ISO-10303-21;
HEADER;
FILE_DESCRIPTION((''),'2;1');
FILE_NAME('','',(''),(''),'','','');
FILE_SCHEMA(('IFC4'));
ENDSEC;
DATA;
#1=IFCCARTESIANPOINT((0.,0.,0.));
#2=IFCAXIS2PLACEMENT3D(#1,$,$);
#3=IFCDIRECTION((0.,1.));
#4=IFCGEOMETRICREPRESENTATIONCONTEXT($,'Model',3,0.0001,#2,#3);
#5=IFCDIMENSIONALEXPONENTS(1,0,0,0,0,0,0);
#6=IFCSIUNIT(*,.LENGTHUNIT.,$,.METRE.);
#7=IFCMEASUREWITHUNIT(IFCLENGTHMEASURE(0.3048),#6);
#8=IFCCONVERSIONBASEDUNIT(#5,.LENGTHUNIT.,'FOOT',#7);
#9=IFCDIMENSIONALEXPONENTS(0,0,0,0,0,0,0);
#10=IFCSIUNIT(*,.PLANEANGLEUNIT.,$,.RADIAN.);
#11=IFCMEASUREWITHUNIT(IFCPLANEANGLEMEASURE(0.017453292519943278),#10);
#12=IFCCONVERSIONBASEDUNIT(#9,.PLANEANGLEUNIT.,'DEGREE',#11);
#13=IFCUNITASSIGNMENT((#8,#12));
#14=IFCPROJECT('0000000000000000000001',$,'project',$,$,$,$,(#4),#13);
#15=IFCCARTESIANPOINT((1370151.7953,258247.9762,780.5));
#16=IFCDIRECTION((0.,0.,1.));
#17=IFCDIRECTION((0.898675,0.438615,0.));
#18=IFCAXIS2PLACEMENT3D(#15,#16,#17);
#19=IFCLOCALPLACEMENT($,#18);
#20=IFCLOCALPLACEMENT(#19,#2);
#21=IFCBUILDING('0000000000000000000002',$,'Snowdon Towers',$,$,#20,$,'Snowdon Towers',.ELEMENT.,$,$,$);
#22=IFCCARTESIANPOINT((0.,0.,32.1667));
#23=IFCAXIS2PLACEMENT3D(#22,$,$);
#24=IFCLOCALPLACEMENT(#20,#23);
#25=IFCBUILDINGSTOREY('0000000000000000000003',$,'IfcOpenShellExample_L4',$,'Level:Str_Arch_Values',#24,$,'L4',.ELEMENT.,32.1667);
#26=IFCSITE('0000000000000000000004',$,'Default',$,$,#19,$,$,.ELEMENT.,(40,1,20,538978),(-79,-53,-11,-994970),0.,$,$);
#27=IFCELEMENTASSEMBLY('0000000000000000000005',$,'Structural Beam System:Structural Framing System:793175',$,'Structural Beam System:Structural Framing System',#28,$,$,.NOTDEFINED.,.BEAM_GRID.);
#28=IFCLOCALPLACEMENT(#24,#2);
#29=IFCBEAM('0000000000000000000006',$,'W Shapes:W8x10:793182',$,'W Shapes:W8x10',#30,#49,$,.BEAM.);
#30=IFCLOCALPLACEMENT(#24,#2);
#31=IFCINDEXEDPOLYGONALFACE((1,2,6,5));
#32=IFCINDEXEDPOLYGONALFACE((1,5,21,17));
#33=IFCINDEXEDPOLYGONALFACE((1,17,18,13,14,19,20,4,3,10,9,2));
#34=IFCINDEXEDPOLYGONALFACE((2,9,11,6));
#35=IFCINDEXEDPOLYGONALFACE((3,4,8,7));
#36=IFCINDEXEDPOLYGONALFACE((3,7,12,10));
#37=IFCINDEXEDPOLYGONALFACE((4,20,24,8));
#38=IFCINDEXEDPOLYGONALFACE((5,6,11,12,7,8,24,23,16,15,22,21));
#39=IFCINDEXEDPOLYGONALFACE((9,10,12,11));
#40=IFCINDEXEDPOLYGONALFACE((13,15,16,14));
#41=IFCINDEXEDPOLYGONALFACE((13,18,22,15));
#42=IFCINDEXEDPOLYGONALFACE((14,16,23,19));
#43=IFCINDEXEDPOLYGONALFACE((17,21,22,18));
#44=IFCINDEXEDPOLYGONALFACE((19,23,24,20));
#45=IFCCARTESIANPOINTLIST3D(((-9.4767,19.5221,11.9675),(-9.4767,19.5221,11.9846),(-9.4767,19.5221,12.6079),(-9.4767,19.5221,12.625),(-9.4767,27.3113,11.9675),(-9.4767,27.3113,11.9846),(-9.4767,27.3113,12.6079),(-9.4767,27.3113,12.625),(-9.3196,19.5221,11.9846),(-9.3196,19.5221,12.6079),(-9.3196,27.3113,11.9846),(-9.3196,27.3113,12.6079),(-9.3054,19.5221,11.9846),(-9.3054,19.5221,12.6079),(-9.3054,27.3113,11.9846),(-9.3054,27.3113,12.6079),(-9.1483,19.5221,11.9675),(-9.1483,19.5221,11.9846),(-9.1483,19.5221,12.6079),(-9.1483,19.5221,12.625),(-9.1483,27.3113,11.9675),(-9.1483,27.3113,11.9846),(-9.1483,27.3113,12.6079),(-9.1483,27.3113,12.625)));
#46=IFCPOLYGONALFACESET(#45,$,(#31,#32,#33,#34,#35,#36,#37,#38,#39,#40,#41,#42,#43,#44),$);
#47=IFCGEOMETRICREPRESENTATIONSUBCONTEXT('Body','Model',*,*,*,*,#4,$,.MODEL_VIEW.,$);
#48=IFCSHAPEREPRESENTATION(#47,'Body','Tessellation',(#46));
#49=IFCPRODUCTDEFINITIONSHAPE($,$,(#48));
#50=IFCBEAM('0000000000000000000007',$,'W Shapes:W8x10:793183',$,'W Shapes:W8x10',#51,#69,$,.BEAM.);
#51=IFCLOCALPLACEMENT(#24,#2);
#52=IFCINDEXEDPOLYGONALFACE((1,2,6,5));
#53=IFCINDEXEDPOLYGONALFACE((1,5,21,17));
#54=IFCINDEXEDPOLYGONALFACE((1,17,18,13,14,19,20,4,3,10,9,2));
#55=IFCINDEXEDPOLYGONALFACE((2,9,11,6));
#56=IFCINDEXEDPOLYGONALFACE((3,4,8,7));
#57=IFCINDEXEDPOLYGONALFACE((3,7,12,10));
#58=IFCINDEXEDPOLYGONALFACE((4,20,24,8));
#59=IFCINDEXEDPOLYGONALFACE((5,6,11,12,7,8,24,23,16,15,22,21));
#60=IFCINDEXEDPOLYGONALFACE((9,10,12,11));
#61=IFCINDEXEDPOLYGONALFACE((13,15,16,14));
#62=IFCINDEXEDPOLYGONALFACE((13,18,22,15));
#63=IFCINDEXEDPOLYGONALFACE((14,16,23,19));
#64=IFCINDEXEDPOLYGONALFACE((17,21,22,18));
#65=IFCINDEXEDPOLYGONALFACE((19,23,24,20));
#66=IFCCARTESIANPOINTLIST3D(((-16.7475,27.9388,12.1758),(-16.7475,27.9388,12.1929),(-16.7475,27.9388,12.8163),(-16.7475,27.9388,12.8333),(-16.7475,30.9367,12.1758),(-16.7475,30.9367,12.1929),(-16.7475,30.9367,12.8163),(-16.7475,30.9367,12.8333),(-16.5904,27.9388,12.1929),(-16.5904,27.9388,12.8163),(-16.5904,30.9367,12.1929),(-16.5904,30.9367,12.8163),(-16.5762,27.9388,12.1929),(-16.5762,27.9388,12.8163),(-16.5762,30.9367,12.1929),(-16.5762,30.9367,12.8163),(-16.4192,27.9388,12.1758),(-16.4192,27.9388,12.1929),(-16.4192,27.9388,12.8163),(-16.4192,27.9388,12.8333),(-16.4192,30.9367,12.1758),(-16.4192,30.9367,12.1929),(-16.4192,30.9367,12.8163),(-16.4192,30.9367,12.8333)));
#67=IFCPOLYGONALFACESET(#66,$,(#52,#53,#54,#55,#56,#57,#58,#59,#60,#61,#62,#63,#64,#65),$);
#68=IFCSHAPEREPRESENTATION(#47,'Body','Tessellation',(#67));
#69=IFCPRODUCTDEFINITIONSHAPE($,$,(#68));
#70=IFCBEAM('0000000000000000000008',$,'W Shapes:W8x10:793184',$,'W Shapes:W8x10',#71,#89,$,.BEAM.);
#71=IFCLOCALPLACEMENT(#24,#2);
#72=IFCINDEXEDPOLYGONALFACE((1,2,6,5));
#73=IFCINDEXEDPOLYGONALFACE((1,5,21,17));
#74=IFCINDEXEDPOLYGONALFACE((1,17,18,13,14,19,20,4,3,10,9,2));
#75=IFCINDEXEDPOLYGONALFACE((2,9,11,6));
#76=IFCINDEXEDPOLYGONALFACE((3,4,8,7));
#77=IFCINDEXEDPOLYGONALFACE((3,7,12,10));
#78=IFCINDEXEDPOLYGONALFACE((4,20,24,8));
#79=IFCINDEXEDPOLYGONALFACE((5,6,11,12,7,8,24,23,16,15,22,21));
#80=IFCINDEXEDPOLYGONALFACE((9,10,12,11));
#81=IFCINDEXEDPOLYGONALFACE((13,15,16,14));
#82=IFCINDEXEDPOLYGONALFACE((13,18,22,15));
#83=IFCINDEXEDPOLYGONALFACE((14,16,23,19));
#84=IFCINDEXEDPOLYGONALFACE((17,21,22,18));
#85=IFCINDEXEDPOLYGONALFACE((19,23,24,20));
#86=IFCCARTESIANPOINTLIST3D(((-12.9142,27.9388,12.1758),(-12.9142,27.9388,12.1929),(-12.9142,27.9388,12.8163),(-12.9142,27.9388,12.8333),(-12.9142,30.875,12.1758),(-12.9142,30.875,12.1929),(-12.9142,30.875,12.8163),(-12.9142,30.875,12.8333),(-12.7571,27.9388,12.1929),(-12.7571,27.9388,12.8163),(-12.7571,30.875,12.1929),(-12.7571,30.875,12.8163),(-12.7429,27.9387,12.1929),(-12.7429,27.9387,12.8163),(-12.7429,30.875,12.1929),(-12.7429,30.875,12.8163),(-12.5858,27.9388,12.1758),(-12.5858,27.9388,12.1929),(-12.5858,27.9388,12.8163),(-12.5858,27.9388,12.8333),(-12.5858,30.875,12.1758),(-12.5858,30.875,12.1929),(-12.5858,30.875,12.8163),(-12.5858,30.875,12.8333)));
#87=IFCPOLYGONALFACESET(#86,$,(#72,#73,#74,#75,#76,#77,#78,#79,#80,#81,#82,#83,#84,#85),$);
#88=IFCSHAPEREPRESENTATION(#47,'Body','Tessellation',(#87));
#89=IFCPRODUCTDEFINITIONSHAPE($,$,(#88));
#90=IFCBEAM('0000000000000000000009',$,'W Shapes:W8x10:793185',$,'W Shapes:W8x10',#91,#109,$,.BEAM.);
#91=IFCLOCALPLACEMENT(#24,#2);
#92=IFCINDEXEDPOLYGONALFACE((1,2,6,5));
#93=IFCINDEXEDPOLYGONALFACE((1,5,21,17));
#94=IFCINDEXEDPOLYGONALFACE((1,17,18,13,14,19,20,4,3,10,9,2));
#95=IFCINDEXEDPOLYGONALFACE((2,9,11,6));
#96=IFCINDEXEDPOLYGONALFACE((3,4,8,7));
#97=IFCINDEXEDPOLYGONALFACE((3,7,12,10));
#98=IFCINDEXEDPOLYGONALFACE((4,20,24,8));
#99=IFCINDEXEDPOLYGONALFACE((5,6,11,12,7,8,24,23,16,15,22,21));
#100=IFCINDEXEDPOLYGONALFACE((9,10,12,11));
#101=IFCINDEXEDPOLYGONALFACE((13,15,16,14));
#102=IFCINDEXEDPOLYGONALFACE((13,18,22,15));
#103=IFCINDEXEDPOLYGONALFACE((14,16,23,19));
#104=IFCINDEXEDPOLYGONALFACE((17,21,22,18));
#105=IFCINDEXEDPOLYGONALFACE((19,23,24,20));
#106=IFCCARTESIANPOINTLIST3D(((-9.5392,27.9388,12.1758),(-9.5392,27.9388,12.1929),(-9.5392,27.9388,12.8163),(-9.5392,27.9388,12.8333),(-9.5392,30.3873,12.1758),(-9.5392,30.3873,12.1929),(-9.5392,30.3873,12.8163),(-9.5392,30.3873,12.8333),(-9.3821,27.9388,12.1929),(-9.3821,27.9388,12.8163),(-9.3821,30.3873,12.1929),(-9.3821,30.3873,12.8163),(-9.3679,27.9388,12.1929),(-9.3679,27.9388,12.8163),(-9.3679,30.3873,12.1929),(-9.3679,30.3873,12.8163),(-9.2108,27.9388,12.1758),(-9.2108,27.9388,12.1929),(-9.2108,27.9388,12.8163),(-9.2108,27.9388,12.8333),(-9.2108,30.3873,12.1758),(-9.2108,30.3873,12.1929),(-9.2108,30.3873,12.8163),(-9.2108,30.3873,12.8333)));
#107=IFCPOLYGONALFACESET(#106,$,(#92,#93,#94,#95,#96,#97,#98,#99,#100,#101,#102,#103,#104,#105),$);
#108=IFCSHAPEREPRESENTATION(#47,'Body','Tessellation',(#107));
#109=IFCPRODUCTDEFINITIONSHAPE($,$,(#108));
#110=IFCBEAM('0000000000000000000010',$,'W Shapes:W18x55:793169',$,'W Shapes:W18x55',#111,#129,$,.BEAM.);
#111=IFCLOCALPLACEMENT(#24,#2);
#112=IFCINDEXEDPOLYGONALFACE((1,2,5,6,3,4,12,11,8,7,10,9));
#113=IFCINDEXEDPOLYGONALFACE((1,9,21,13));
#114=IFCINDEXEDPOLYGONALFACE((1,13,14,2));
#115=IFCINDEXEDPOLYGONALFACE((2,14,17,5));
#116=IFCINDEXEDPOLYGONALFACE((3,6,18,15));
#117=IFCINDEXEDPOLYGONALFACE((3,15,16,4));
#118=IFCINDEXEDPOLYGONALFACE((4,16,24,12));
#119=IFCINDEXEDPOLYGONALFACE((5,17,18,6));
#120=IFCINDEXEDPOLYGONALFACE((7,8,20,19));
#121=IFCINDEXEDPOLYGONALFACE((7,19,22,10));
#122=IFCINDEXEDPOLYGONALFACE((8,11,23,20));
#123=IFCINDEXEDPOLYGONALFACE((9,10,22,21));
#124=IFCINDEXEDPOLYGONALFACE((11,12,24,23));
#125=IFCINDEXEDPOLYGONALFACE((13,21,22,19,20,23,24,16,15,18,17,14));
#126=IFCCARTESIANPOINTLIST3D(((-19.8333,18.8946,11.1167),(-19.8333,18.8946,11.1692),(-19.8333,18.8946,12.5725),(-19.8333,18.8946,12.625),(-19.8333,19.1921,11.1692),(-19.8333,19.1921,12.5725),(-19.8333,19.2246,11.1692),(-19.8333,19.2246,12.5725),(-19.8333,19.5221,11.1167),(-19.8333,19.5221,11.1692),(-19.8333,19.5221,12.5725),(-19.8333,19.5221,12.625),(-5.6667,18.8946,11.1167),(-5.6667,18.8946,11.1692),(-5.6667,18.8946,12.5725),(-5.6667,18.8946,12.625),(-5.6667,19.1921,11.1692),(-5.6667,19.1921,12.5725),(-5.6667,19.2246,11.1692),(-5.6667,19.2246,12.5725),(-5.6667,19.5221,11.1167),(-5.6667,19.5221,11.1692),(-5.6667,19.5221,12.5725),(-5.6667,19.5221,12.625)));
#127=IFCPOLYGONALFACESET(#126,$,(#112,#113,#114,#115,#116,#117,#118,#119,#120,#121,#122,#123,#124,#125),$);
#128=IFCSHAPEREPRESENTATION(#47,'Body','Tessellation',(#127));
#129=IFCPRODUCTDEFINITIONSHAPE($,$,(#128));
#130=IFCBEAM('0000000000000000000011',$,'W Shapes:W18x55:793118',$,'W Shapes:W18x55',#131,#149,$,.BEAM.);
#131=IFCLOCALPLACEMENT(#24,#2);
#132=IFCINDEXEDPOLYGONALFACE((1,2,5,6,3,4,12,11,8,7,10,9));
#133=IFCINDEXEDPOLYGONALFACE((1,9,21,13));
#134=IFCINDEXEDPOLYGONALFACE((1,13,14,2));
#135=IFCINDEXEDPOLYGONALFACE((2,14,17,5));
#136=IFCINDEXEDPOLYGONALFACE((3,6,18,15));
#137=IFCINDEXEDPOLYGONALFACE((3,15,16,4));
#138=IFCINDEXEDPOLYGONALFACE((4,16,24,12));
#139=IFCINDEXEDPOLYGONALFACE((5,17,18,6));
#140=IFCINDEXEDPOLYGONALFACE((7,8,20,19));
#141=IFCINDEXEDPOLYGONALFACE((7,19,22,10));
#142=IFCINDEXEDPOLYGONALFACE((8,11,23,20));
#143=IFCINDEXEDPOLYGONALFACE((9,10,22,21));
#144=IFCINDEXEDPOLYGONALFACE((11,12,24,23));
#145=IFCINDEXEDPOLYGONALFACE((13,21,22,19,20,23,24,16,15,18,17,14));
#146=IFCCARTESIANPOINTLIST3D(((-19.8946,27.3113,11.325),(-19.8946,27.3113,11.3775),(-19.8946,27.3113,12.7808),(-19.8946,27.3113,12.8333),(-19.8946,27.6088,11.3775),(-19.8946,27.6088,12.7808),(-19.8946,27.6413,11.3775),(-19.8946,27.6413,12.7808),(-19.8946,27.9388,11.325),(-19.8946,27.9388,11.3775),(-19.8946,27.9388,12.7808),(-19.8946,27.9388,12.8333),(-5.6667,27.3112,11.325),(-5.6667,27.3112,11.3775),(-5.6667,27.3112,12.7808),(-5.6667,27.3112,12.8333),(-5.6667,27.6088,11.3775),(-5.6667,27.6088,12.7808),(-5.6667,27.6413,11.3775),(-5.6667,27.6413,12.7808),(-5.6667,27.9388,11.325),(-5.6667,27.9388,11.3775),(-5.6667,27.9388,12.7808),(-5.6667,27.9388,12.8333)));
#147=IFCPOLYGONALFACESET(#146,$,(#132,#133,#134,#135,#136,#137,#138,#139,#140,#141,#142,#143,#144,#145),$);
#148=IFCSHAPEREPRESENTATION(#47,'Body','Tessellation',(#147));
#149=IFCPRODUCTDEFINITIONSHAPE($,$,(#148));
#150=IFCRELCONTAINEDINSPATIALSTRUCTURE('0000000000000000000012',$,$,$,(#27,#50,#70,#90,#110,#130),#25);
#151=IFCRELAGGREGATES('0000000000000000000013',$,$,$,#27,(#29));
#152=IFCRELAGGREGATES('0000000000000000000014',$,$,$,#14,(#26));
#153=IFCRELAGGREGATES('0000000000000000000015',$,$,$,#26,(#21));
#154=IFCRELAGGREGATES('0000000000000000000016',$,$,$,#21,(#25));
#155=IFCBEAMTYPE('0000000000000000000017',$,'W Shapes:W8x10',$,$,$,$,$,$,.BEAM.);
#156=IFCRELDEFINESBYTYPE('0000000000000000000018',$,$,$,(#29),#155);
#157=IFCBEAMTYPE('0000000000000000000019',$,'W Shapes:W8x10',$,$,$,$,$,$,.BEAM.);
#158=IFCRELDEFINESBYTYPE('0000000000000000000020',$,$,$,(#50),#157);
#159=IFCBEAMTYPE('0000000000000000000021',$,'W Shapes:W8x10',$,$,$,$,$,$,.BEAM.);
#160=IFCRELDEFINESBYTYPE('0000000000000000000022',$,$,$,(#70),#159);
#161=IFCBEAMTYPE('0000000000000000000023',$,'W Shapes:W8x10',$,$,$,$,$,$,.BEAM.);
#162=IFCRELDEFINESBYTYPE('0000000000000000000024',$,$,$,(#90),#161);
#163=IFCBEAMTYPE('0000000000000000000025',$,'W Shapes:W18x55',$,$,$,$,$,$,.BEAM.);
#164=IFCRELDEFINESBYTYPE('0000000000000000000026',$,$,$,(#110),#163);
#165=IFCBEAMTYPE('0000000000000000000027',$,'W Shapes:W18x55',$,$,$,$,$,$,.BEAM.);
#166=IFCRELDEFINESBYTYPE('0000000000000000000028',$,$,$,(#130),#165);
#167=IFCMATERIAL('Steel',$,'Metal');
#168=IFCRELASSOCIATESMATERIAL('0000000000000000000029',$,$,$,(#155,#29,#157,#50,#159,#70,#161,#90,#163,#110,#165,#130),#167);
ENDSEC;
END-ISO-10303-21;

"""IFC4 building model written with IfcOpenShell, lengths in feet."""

from ifc_helpers import new_model, entity, si_unit, converted_unit, direction, frame, origin, place, context, subcontext, project, spatial, indexed_curve, outline, extrude, source, transform, mapped, material, type_object, type_shapes, element, aggregate, save


model = new_model("IFC4")

# Units and contexts
model_context = context("Model", 3, precision=0.0001, world=origin(), true_north=direction((0.0, 1.0)))
body_context = subcontext(model_context, "Body", "Model", "MODEL_VIEW")
ifc_project = project(units=[converted_unit("LENGTHUNIT", "FOOT", entity("IfcLengthMeasure", 0.3048), si_unit("LENGTHUNIT", "METRE"), dimensions=[1, 0, 0, 0, 0, 0, 0]), converted_unit("PLANEANGLEUNIT", "DEGREE", entity("IfcPlaneAngleMeasure", 0.017453292519943278), si_unit("PLANEANGLEUNIT", "RADIAN"), dimensions=[0, 0, 0, 0, 0, 0, 0])], contexts=[model_context])

# Site, building, storey
site_placement = place(None, frame((1370151.7953, 258247.9762, 780.5), z_axis=(0.0, 0.0, 1.0), x_axis=(0.898675, 0.438615, 0.0)))
site = spatial("IfcSite", under=ifc_project, at=site_placement, Name="Default", CompositionType="ELEMENT", RefLatitude=(40, 1, 20, 538978), RefLongitude=(-79, -53, -11, -994970), RefElevation=0.0)
building_placement = place(site_placement, origin())
building = spatial("IfcBuilding", under=site, at=building_placement, Name="Snowdon Towers", LongName="Snowdon Towers", CompositionType="ELEMENT")
storey_placement = place(building_placement, frame((0.0, 0.0, 32.1667)))
storey = spatial("IfcBuildingStorey", under=building, at=storey_placement, Name="IfcOpenShellExample_L4", ObjectType="Level:Str_Arch_Values", LongName="L4", CompositionType="ELEMENT", Elevation=32.1667)

# Shared definitions
ifc_material = material(Name="Steel", Category="Metal")

# Element assembly, beam
assembly_1_placement = place(storey_placement, origin())
assembly_1 = element("IfcElementAssembly", 1, at=assembly_1_placement, inside=storey, Name="Structural Beam System:Structural Framing System:793175", ObjectType="Structural Beam System:Structural Framing System", AssemblyPlace="NOTDEFINED", PredefinedType="BEAM_GRID")
beam_type_1 = type_object("IfcBeamType", Name="W Shapes:W8x10", PredefinedType="BEAM", material=ifc_material)
shared_shape_1 = source(origin(), body_context, "Body", "SweptSolid", [
    extrude(outline(indexed_curve([(-0.1642, -0.3117), (-0.1642, -0.3288), (0.1642, -0.3288), (0.1642, -0.3117), (0.0071, -0.3117), (0.0071, 0.3117), (0.1642, 0.3117), (0.1642, 0.3287), (-0.1642, 0.3287), (-0.1642, 0.3117), (-0.0071, 0.3117), (-0.0071, -0.3117), (-0.1642, -0.3117)], self_intersect=False)), frame((-3.8946, 0.0, 0.0), z_axis=(-1.0, 0.0, 0.0), x_axis=(0.0, -1.0, 0.0)), (0.0, 0.0, -1.0), 7.7892),
])
type_shapes(beam_type_1, [shared_shape_1])
beam_1_placement = place(assembly_1_placement, frame((-9.3125, 23.4167, 12.2963), z_axis=(0.0, 0.0, 1.0), x_axis=(0.0, 1.0, 0.0)))
beam_1 = element("IfcBeam", 2, at=beam_1_placement, type_object=beam_type_1, material=ifc_material, Name="W Shapes:W8x10:793182", ObjectType="W Shapes:W8x10", PredefinedType="BEAM", context=body_context, shape_type="MappedRepresentation", body=[
    mapped(shared_shape_1, transform((0.0, 0.0, 0.0), scale=1.0)),
])
aggregate(assembly_1, [beam_1])

# Beams
beam_type_2 = type_object("IfcBeamType", Name="W Shapes:W8x10", PredefinedType="BEAM", material=ifc_material)
shared_shape_2 = source(origin(), body_context, "Body", "SweptSolid", [
    extrude(outline(indexed_curve([(-0.1642, -0.3117), (-0.1642, -0.3288), (0.1642, -0.3288), (0.1642, -0.3117), (0.0071, -0.3117), (0.0071, 0.3117), (0.1642, 0.3117), (0.1642, 0.3287), (-0.1642, 0.3287), (-0.1642, 0.3117), (-0.0071, 0.3117), (-0.0071, -0.3117), (-0.1642, -0.3117)], self_intersect=False)), frame((-1.3421, 0.0, 0.0), z_axis=(-1.0, 0.0, 0.0), x_axis=(0.0, -1.0, 0.0)), (0.0, 0.0, -1.0), 2.9979),
])
type_shapes(beam_type_2, [shared_shape_2])
beam_2_placement = place(storey_placement, frame((-16.5833, 29.2808, 12.5046), z_axis=(0.0, 0.0, 1.0), x_axis=(0.0, 1.0, 0.0)))
element("IfcBeam", 3, at=beam_2_placement, inside=storey, type_object=beam_type_2, material=ifc_material, Name="W Shapes:W8x10:793183", ObjectType="W Shapes:W8x10", PredefinedType="BEAM", context=body_context, shape_type="MappedRepresentation", body=[
    mapped(shared_shape_2, transform((0.0, 0.0, 0.0), scale=1.0)),
])
beam_type_3 = type_object("IfcBeamType", Name="W Shapes:W8x10", PredefinedType="BEAM", material=ifc_material)
shared_shape_3 = source(origin(), body_context, "Body", "SweptSolid", [
    extrude(outline(indexed_curve([(-0.1642, -0.3117), (-0.1642, -0.3288), (0.1642, -0.3288), (0.1642, -0.3117), (0.0071, -0.3117), (0.0071, 0.3117), (0.1642, 0.3117), (0.1642, 0.3287), (-0.1642, 0.3287), (-0.1642, 0.3117), (-0.0071, 0.3117), (-0.0071, -0.3117), (-0.1642, -0.3117)], self_intersect=False)), frame((-1.3113, 0.0, 0.0), z_axis=(-1.0, 0.0, 0.0), x_axis=(0.0, -1.0, 0.0)), (0.0, 0.0, -1.0), 2.9363),
])
type_shapes(beam_type_3, [shared_shape_3])
beam_3_placement = place(storey_placement, frame((-12.75, 29.25, 12.5046), z_axis=(0.0, 0.0, 1.0), x_axis=(0.0, 1.0, 0.0)))
element("IfcBeam", 4, at=beam_3_placement, inside=storey, type_object=beam_type_3, material=ifc_material, Name="W Shapes:W8x10:793184", ObjectType="W Shapes:W8x10", PredefinedType="BEAM", context=body_context, shape_type="MappedRepresentation", body=[
    mapped(shared_shape_3, transform((0.0, 0.0, 0.0), scale=1.0)),
])
beam_type_4 = type_object("IfcBeamType", Name="W Shapes:W8x10", PredefinedType="BEAM", material=ifc_material)
shared_shape_4 = source(origin(), body_context, "Body", "SweptSolid", [
    extrude(outline(indexed_curve([(-0.1642, -0.3117), (-0.1642, -0.3288), (0.1642, -0.3288), (0.1642, -0.3117), (0.0071, -0.3117), (0.0071, 0.3117), (0.1642, 0.3117), (0.1642, 0.3287), (-0.1642, 0.3287), (-0.1642, 0.3117), (-0.0071, 0.3117), (-0.0071, -0.3117), (-0.1642, -0.3117)], self_intersect=False)), frame((-1.1834, 0.0, 0.0), z_axis=(-1.0, 0.0, 0.0), x_axis=(0.0, -1.0, 0.0)), (0.0, 0.0, -1.0), 2.4485),
])
type_shapes(beam_type_4, [shared_shape_4])
beam_4_placement = place(storey_placement, frame((-9.375, 29.1222, 12.5046), z_axis=(0.0, 0.0, 1.0), x_axis=(0.0, 1.0, 0.0)))
element("IfcBeam", 5, at=beam_4_placement, inside=storey, type_object=beam_type_4, material=ifc_material, Name="W Shapes:W8x10:793185", ObjectType="W Shapes:W8x10", PredefinedType="BEAM", context=body_context, shape_type="MappedRepresentation", body=[
    mapped(shared_shape_4, transform((0.0, 0.0, 0.0), scale=1.0)),
])
beam_type_5 = type_object("IfcBeamType", Name="W Shapes:W18x55", PredefinedType="BEAM", material=ifc_material)
shared_shape_5 = source(origin(), body_context, "Body", "SweptSolid", [
    extrude(outline(indexed_curve([(-0.3138, -0.7017), (-0.3138, -0.7542), (0.3138, -0.7542), (0.3138, -0.7017), (0.0162, -0.7017), (0.0162, 0.7017), (0.3138, 0.7017), (0.3138, 0.7542), (-0.3137, 0.7542), (-0.3137, 0.7017), (-0.0163, 0.7017), (-0.0163, -0.7017), (-0.3138, -0.7017)], self_intersect=False)), frame((-7.2917, 0.0, 0.0), z_axis=(-1.0, 0.0, 0.0), x_axis=(0.0, -1.0, 0.0)), (0.0, 0.0, -1.0), 14.1667),
])
type_shapes(beam_type_5, [shared_shape_5])
beam_5_placement = place(storey_placement, frame((-12.9583, 19.2083, 11.8708), z_axis=(0.0, 0.0, 1.0), x_axis=(-1.0, 0.0, 0.0)))
element("IfcBeam", 6, at=beam_5_placement, inside=storey, type_object=beam_type_5, material=ifc_material, Name="W Shapes:W18x55:793169", ObjectType="W Shapes:W18x55", PredefinedType="BEAM", context=body_context, shape_type="MappedRepresentation", body=[
    mapped(shared_shape_5, transform((0.0, 0.0, 0.0), scale=1.0)),
])

# Beam
beam_type_6 = type_object("IfcBeamType", Name="W Shapes:W18x55", PredefinedType="BEAM", material=ifc_material)
shared_shape_6 = source(origin(), body_context, "Body", "SweptSolid", [
    extrude(outline(indexed_curve([(-0.3138, -0.7017), (-0.3138, -0.7542), (0.3138, -0.7542), (0.3138, -0.7017), (0.0162, -0.7017), (0.0162, 0.7017), (0.3138, 0.7017), (0.3138, 0.7542), (-0.3137, 0.7542), (-0.3137, 0.7017), (-0.0163, 0.7017), (-0.0163, -0.7017), (-0.3138, -0.7017)], self_intersect=False)), frame((-7.2917, 0.0, 0.0), z_axis=(-1.0, 0.0, 0.0), x_axis=(0.0, -1.0, 0.0)), (0.0, 0.0, -1.0), 14.2279),
])
type_shapes(beam_type_6, [shared_shape_6])
beam_6_placement = place(storey_placement, frame((-12.9583, 27.625, 12.0792), z_axis=(0.0, 0.0, 1.0), x_axis=(-1.0, 0.0, 0.0)))
element("IfcBeam", 7, at=beam_6_placement, inside=storey, type_object=beam_type_6, material=ifc_material, Name="W Shapes:W18x55:793118", ObjectType="W Shapes:W18x55", PredefinedType="BEAM", context=body_context, shape_type="MappedRepresentation", body=[
    mapped(shared_shape_6, transform((0.0, 0.0, 0.0), scale=1.0)),
])

save(model, "model.ifc")
